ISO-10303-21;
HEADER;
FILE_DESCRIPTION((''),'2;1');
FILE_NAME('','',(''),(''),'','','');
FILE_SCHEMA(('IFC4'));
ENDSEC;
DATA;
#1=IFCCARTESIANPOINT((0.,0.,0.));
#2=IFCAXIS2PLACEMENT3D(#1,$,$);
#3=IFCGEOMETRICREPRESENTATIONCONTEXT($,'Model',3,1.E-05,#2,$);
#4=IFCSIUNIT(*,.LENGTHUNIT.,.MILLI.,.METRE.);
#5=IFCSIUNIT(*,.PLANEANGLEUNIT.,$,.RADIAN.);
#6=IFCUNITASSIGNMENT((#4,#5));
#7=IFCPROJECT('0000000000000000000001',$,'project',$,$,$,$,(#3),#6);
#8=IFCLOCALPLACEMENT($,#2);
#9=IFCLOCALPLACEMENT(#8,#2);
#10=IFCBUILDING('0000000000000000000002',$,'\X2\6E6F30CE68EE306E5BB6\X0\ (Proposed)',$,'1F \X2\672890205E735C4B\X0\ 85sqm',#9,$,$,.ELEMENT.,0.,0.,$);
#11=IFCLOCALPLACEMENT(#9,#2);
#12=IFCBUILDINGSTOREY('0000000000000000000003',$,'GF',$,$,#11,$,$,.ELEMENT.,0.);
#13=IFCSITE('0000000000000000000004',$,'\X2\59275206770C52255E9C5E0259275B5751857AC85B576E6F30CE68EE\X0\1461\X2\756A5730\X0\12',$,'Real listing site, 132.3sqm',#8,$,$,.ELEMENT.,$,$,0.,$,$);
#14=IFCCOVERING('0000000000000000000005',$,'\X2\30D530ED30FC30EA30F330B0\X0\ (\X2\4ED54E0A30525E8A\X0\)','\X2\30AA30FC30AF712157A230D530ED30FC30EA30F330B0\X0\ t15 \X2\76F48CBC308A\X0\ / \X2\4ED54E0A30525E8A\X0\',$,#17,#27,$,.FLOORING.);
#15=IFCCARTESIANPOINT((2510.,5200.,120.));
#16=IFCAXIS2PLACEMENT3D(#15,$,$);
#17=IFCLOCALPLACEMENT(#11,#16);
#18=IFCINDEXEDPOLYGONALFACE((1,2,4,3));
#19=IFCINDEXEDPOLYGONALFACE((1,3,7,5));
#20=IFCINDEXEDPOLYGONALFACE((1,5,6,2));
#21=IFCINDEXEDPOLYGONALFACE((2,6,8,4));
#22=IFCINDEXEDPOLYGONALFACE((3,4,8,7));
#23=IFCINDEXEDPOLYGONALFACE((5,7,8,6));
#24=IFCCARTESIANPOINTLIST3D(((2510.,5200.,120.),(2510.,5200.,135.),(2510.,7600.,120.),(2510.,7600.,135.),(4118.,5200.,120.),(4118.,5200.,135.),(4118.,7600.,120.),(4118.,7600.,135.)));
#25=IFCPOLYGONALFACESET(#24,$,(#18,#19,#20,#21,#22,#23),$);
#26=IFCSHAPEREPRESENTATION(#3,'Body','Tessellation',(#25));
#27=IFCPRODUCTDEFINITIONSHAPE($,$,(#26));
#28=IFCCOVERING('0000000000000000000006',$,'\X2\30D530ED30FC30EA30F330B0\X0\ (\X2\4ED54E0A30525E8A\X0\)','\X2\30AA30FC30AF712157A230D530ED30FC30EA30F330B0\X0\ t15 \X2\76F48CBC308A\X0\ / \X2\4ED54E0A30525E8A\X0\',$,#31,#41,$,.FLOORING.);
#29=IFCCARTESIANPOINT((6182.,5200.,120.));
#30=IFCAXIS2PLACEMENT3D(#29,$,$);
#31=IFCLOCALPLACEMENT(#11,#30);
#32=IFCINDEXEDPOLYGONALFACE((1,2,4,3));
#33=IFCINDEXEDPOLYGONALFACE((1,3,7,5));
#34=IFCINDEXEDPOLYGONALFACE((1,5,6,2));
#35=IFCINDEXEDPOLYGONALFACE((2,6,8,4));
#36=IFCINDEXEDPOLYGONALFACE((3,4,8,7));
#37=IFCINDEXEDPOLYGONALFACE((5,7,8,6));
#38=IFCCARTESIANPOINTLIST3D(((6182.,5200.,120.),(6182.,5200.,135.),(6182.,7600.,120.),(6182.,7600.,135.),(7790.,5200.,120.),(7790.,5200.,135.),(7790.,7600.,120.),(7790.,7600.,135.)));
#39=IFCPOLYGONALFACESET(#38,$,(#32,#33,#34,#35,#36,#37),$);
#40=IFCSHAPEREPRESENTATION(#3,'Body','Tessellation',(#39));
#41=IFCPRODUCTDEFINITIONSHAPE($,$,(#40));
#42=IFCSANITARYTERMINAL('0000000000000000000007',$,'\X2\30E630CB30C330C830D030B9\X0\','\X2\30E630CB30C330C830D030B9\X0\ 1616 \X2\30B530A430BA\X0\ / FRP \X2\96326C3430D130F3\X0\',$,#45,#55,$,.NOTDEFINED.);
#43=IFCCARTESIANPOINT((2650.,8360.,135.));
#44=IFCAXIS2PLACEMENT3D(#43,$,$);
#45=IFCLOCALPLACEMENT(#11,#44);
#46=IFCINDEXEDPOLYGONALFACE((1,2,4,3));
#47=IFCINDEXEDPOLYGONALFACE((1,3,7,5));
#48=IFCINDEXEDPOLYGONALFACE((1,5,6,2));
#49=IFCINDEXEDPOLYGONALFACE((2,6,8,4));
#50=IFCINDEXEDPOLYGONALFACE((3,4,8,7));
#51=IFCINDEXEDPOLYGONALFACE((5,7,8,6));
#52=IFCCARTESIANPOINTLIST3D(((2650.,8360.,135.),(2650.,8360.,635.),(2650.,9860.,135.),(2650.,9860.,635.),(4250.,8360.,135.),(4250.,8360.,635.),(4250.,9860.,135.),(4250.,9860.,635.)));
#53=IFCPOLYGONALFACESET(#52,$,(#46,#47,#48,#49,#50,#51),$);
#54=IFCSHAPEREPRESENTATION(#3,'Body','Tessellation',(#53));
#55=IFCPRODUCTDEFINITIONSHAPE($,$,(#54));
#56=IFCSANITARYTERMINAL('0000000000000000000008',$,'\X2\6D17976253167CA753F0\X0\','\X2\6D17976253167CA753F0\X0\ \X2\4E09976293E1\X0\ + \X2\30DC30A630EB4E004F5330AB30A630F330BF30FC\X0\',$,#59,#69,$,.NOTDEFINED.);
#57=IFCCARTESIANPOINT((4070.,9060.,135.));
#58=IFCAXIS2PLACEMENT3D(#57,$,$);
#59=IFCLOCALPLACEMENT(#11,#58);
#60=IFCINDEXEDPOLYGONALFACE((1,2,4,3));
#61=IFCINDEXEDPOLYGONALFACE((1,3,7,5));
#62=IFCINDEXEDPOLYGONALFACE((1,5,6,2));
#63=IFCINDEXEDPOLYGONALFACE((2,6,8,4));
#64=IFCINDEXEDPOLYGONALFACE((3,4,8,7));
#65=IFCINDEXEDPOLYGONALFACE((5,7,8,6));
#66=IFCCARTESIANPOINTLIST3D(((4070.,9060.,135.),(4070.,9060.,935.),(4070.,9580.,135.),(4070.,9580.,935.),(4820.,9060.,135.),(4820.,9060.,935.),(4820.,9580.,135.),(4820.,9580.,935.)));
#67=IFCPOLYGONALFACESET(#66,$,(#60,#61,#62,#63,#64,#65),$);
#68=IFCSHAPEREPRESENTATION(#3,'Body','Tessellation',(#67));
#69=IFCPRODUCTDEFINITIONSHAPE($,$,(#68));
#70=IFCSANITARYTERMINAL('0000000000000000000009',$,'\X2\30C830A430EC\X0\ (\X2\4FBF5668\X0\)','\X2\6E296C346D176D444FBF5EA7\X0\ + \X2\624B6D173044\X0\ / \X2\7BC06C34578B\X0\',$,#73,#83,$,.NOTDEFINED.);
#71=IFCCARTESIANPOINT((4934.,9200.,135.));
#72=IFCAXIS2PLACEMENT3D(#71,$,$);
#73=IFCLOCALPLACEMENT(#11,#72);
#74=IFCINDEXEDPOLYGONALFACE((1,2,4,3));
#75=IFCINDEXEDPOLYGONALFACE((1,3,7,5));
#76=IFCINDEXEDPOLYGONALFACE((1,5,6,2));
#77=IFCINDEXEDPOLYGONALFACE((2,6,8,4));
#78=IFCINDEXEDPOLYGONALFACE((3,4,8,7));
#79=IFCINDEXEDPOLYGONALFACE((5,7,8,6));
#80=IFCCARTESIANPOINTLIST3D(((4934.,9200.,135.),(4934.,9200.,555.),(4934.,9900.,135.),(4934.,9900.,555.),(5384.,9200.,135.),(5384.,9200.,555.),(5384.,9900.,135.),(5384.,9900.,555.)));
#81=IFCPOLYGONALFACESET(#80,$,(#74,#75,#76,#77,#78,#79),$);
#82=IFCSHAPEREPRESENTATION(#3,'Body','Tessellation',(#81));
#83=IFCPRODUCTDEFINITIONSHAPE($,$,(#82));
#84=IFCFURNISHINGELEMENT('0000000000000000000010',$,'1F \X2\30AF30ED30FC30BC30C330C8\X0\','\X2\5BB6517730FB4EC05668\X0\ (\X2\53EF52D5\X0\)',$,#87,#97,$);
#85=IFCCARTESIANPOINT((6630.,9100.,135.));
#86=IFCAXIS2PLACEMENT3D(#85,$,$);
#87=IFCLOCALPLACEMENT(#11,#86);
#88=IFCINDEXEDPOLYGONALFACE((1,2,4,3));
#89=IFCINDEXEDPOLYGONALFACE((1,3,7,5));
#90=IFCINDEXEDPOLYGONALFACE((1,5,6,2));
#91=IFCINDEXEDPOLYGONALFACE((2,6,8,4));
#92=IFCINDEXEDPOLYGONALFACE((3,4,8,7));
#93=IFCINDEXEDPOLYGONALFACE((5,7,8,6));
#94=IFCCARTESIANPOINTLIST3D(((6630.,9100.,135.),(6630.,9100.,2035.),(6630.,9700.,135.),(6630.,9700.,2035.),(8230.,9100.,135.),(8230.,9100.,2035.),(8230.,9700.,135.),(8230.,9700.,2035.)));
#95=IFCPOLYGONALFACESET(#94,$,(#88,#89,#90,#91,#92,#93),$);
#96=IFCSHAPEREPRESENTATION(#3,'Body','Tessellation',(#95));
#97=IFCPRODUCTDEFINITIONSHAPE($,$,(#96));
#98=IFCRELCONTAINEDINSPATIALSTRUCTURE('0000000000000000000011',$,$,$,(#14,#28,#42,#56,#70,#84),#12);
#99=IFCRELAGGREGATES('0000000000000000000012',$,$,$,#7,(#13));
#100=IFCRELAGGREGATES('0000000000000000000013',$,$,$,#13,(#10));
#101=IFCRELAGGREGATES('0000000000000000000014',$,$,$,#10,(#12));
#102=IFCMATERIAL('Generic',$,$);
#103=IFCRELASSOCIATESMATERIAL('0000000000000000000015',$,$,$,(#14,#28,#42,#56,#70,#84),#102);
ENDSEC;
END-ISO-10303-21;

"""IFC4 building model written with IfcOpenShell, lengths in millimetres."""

from ifc_helpers import new_model, si_unit, frame, frame_2d, origin, place, context, project, spatial, rectangle, extrude, material, element, save


model = new_model("IFC4")

# Units and contexts
model_context = context("Model", 3, precision=1e-05, world=origin())
ifc_project = project(units=[si_unit("LENGTHUNIT", "METRE", prefix="MILLI"), si_unit("PLANEANGLEUNIT", "RADIAN")], contexts=[model_context])

# Site, building, storey
site_placement = place(None, origin())
site = spatial("IfcSite", under=ifc_project, at=site_placement, Name="大分県別府市大字内竈字湯ノ森1461番地12", ObjectType="Real listing site, 132.3sqm", CompositionType="ELEMENT", RefElevation=0.0)
building_placement = place(site_placement, origin())
building = spatial("IfcBuilding", under=site, at=building_placement, Name="湯ノ森の家 (Proposed)", ObjectType="1F 木造平屋 85sqm", CompositionType="ELEMENT", ElevationOfRefHeight=0.0, ElevationOfTerrain=0.0)
storey_placement = place(building_placement, origin())
storey = spatial("IfcBuildingStorey", under=building, at=storey_placement, Name="GF", CompositionType="ELEMENT", Elevation=0.0)

# Coverings
ifc_material_1 = material(Name="Generic")
covering_1_placement = place(storey_placement, frame((2510.0, 5200.0, 120.0)))
element("IfcCovering", 1, at=covering_1_placement, inside=storey, material=ifc_material_1, Name="フローリング (仕上げ床)", Description="オーク無垢フローリング t15 直貼り / 仕上げ床", PredefinedType="FLOORING", context=model_context, shape_type="SweptSolid", body=[
    extrude(rectangle(XDim=1608.0, YDim=2400.0, at=frame_2d((804.0, 1200.0))), frame((2510.0, 5200.0, 120.0)), (0.0, 0.0, 1.0), 15.0),
])
covering_2_placement = place(storey_placement, frame((6182.0, 5200.0, 120.0)))
element("IfcCovering", 2, at=covering_2_placement, inside=storey, material=ifc_material_1, Name="フローリング (仕上げ床)", Description="オーク無垢フローリング t15 直貼り / 仕上げ床", PredefinedType="FLOORING", context=model_context, shape_type="SweptSolid", body=[
    extrude(rectangle(XDim=1608.0, YDim=2400.0, at=frame_2d((804.0, 1200.0))), frame((6182.0, 5200.0, 120.0)), (0.0, 0.0, 1.0), 15.0),
])

# Sanitary terminals
sanitary_terminal_1_placement = place(storey_placement, frame((2650.0, 8360.0, 135.0)))
element("IfcSanitaryTerminal", 3, at=sanitary_terminal_1_placement, inside=storey, material=ifc_material_1, Name="ユニットバス", Description="ユニットバス 1616 サイズ / FRP 防水パン", PredefinedType="NOTDEFINED", context=model_context, shape_type="SweptSolid", body=[
    extrude(rectangle(XDim=1600.0, YDim=1500.0, at=frame_2d((800.0, 750.0))), frame((2650.0, 8360.0, 135.0)), (0.0, 0.0, 1.0), 500.0),
])
sanitary_terminal_2_placement = place(storey_placement, frame((4070.0, 9060.0, 135.0)))
element("IfcSanitaryTerminal", 4, at=sanitary_terminal_2_placement, inside=storey, material=ifc_material_1, Name="洗面化粧台", Description="洗面化粧台 三面鏡 + ボウル一体カウンター", PredefinedType="NOTDEFINED", context=model_context, shape_type="SweptSolid", body=[
    extrude(rectangle(XDim=750.0, YDim=520.0, at=frame_2d((375.0, 260.0))), frame((4070.0, 9060.0, 135.0)), (0.0, 0.0, 1.0), 800.0),
])
sanitary_terminal_3_placement = place(storey_placement, frame((4934.0, 9200.0, 135.0)))
element("IfcSanitaryTerminal", 5, at=sanitary_terminal_3_placement, inside=storey, material=ifc_material_1, Name="トイレ (便器)", Description="温水洗浄便座 + 手洗い / 節水型", PredefinedType="NOTDEFINED", context=model_context, shape_type="SweptSolid", body=[
    extrude(rectangle(XDim=450.0, YDim=700.0, at=frame_2d((225.0, 350.0))), frame((4934.0, 9200.0, 135.0)), (0.0, 0.0, 1.0), 420.0),
])

# Furnishing element
furnishing_placement = place(storey_placement, frame((6630.0, 9100.0, 135.0)))
element("IfcFurnishingElement", 6, at=furnishing_placement, inside=storey, material=ifc_material_1, Name="1F クローゼット", Description="家具・什器 (可動)", context=model_context, shape_type="SweptSolid", body=[
    extrude(rectangle(XDim=1600.0, YDim=600.0, at=frame_2d((800.0, 300.0))), frame((6630.0, 9100.0, 135.0)), (0.0, 0.0, 1.0), 1900.0),
])

save(model, "model.ifc")
